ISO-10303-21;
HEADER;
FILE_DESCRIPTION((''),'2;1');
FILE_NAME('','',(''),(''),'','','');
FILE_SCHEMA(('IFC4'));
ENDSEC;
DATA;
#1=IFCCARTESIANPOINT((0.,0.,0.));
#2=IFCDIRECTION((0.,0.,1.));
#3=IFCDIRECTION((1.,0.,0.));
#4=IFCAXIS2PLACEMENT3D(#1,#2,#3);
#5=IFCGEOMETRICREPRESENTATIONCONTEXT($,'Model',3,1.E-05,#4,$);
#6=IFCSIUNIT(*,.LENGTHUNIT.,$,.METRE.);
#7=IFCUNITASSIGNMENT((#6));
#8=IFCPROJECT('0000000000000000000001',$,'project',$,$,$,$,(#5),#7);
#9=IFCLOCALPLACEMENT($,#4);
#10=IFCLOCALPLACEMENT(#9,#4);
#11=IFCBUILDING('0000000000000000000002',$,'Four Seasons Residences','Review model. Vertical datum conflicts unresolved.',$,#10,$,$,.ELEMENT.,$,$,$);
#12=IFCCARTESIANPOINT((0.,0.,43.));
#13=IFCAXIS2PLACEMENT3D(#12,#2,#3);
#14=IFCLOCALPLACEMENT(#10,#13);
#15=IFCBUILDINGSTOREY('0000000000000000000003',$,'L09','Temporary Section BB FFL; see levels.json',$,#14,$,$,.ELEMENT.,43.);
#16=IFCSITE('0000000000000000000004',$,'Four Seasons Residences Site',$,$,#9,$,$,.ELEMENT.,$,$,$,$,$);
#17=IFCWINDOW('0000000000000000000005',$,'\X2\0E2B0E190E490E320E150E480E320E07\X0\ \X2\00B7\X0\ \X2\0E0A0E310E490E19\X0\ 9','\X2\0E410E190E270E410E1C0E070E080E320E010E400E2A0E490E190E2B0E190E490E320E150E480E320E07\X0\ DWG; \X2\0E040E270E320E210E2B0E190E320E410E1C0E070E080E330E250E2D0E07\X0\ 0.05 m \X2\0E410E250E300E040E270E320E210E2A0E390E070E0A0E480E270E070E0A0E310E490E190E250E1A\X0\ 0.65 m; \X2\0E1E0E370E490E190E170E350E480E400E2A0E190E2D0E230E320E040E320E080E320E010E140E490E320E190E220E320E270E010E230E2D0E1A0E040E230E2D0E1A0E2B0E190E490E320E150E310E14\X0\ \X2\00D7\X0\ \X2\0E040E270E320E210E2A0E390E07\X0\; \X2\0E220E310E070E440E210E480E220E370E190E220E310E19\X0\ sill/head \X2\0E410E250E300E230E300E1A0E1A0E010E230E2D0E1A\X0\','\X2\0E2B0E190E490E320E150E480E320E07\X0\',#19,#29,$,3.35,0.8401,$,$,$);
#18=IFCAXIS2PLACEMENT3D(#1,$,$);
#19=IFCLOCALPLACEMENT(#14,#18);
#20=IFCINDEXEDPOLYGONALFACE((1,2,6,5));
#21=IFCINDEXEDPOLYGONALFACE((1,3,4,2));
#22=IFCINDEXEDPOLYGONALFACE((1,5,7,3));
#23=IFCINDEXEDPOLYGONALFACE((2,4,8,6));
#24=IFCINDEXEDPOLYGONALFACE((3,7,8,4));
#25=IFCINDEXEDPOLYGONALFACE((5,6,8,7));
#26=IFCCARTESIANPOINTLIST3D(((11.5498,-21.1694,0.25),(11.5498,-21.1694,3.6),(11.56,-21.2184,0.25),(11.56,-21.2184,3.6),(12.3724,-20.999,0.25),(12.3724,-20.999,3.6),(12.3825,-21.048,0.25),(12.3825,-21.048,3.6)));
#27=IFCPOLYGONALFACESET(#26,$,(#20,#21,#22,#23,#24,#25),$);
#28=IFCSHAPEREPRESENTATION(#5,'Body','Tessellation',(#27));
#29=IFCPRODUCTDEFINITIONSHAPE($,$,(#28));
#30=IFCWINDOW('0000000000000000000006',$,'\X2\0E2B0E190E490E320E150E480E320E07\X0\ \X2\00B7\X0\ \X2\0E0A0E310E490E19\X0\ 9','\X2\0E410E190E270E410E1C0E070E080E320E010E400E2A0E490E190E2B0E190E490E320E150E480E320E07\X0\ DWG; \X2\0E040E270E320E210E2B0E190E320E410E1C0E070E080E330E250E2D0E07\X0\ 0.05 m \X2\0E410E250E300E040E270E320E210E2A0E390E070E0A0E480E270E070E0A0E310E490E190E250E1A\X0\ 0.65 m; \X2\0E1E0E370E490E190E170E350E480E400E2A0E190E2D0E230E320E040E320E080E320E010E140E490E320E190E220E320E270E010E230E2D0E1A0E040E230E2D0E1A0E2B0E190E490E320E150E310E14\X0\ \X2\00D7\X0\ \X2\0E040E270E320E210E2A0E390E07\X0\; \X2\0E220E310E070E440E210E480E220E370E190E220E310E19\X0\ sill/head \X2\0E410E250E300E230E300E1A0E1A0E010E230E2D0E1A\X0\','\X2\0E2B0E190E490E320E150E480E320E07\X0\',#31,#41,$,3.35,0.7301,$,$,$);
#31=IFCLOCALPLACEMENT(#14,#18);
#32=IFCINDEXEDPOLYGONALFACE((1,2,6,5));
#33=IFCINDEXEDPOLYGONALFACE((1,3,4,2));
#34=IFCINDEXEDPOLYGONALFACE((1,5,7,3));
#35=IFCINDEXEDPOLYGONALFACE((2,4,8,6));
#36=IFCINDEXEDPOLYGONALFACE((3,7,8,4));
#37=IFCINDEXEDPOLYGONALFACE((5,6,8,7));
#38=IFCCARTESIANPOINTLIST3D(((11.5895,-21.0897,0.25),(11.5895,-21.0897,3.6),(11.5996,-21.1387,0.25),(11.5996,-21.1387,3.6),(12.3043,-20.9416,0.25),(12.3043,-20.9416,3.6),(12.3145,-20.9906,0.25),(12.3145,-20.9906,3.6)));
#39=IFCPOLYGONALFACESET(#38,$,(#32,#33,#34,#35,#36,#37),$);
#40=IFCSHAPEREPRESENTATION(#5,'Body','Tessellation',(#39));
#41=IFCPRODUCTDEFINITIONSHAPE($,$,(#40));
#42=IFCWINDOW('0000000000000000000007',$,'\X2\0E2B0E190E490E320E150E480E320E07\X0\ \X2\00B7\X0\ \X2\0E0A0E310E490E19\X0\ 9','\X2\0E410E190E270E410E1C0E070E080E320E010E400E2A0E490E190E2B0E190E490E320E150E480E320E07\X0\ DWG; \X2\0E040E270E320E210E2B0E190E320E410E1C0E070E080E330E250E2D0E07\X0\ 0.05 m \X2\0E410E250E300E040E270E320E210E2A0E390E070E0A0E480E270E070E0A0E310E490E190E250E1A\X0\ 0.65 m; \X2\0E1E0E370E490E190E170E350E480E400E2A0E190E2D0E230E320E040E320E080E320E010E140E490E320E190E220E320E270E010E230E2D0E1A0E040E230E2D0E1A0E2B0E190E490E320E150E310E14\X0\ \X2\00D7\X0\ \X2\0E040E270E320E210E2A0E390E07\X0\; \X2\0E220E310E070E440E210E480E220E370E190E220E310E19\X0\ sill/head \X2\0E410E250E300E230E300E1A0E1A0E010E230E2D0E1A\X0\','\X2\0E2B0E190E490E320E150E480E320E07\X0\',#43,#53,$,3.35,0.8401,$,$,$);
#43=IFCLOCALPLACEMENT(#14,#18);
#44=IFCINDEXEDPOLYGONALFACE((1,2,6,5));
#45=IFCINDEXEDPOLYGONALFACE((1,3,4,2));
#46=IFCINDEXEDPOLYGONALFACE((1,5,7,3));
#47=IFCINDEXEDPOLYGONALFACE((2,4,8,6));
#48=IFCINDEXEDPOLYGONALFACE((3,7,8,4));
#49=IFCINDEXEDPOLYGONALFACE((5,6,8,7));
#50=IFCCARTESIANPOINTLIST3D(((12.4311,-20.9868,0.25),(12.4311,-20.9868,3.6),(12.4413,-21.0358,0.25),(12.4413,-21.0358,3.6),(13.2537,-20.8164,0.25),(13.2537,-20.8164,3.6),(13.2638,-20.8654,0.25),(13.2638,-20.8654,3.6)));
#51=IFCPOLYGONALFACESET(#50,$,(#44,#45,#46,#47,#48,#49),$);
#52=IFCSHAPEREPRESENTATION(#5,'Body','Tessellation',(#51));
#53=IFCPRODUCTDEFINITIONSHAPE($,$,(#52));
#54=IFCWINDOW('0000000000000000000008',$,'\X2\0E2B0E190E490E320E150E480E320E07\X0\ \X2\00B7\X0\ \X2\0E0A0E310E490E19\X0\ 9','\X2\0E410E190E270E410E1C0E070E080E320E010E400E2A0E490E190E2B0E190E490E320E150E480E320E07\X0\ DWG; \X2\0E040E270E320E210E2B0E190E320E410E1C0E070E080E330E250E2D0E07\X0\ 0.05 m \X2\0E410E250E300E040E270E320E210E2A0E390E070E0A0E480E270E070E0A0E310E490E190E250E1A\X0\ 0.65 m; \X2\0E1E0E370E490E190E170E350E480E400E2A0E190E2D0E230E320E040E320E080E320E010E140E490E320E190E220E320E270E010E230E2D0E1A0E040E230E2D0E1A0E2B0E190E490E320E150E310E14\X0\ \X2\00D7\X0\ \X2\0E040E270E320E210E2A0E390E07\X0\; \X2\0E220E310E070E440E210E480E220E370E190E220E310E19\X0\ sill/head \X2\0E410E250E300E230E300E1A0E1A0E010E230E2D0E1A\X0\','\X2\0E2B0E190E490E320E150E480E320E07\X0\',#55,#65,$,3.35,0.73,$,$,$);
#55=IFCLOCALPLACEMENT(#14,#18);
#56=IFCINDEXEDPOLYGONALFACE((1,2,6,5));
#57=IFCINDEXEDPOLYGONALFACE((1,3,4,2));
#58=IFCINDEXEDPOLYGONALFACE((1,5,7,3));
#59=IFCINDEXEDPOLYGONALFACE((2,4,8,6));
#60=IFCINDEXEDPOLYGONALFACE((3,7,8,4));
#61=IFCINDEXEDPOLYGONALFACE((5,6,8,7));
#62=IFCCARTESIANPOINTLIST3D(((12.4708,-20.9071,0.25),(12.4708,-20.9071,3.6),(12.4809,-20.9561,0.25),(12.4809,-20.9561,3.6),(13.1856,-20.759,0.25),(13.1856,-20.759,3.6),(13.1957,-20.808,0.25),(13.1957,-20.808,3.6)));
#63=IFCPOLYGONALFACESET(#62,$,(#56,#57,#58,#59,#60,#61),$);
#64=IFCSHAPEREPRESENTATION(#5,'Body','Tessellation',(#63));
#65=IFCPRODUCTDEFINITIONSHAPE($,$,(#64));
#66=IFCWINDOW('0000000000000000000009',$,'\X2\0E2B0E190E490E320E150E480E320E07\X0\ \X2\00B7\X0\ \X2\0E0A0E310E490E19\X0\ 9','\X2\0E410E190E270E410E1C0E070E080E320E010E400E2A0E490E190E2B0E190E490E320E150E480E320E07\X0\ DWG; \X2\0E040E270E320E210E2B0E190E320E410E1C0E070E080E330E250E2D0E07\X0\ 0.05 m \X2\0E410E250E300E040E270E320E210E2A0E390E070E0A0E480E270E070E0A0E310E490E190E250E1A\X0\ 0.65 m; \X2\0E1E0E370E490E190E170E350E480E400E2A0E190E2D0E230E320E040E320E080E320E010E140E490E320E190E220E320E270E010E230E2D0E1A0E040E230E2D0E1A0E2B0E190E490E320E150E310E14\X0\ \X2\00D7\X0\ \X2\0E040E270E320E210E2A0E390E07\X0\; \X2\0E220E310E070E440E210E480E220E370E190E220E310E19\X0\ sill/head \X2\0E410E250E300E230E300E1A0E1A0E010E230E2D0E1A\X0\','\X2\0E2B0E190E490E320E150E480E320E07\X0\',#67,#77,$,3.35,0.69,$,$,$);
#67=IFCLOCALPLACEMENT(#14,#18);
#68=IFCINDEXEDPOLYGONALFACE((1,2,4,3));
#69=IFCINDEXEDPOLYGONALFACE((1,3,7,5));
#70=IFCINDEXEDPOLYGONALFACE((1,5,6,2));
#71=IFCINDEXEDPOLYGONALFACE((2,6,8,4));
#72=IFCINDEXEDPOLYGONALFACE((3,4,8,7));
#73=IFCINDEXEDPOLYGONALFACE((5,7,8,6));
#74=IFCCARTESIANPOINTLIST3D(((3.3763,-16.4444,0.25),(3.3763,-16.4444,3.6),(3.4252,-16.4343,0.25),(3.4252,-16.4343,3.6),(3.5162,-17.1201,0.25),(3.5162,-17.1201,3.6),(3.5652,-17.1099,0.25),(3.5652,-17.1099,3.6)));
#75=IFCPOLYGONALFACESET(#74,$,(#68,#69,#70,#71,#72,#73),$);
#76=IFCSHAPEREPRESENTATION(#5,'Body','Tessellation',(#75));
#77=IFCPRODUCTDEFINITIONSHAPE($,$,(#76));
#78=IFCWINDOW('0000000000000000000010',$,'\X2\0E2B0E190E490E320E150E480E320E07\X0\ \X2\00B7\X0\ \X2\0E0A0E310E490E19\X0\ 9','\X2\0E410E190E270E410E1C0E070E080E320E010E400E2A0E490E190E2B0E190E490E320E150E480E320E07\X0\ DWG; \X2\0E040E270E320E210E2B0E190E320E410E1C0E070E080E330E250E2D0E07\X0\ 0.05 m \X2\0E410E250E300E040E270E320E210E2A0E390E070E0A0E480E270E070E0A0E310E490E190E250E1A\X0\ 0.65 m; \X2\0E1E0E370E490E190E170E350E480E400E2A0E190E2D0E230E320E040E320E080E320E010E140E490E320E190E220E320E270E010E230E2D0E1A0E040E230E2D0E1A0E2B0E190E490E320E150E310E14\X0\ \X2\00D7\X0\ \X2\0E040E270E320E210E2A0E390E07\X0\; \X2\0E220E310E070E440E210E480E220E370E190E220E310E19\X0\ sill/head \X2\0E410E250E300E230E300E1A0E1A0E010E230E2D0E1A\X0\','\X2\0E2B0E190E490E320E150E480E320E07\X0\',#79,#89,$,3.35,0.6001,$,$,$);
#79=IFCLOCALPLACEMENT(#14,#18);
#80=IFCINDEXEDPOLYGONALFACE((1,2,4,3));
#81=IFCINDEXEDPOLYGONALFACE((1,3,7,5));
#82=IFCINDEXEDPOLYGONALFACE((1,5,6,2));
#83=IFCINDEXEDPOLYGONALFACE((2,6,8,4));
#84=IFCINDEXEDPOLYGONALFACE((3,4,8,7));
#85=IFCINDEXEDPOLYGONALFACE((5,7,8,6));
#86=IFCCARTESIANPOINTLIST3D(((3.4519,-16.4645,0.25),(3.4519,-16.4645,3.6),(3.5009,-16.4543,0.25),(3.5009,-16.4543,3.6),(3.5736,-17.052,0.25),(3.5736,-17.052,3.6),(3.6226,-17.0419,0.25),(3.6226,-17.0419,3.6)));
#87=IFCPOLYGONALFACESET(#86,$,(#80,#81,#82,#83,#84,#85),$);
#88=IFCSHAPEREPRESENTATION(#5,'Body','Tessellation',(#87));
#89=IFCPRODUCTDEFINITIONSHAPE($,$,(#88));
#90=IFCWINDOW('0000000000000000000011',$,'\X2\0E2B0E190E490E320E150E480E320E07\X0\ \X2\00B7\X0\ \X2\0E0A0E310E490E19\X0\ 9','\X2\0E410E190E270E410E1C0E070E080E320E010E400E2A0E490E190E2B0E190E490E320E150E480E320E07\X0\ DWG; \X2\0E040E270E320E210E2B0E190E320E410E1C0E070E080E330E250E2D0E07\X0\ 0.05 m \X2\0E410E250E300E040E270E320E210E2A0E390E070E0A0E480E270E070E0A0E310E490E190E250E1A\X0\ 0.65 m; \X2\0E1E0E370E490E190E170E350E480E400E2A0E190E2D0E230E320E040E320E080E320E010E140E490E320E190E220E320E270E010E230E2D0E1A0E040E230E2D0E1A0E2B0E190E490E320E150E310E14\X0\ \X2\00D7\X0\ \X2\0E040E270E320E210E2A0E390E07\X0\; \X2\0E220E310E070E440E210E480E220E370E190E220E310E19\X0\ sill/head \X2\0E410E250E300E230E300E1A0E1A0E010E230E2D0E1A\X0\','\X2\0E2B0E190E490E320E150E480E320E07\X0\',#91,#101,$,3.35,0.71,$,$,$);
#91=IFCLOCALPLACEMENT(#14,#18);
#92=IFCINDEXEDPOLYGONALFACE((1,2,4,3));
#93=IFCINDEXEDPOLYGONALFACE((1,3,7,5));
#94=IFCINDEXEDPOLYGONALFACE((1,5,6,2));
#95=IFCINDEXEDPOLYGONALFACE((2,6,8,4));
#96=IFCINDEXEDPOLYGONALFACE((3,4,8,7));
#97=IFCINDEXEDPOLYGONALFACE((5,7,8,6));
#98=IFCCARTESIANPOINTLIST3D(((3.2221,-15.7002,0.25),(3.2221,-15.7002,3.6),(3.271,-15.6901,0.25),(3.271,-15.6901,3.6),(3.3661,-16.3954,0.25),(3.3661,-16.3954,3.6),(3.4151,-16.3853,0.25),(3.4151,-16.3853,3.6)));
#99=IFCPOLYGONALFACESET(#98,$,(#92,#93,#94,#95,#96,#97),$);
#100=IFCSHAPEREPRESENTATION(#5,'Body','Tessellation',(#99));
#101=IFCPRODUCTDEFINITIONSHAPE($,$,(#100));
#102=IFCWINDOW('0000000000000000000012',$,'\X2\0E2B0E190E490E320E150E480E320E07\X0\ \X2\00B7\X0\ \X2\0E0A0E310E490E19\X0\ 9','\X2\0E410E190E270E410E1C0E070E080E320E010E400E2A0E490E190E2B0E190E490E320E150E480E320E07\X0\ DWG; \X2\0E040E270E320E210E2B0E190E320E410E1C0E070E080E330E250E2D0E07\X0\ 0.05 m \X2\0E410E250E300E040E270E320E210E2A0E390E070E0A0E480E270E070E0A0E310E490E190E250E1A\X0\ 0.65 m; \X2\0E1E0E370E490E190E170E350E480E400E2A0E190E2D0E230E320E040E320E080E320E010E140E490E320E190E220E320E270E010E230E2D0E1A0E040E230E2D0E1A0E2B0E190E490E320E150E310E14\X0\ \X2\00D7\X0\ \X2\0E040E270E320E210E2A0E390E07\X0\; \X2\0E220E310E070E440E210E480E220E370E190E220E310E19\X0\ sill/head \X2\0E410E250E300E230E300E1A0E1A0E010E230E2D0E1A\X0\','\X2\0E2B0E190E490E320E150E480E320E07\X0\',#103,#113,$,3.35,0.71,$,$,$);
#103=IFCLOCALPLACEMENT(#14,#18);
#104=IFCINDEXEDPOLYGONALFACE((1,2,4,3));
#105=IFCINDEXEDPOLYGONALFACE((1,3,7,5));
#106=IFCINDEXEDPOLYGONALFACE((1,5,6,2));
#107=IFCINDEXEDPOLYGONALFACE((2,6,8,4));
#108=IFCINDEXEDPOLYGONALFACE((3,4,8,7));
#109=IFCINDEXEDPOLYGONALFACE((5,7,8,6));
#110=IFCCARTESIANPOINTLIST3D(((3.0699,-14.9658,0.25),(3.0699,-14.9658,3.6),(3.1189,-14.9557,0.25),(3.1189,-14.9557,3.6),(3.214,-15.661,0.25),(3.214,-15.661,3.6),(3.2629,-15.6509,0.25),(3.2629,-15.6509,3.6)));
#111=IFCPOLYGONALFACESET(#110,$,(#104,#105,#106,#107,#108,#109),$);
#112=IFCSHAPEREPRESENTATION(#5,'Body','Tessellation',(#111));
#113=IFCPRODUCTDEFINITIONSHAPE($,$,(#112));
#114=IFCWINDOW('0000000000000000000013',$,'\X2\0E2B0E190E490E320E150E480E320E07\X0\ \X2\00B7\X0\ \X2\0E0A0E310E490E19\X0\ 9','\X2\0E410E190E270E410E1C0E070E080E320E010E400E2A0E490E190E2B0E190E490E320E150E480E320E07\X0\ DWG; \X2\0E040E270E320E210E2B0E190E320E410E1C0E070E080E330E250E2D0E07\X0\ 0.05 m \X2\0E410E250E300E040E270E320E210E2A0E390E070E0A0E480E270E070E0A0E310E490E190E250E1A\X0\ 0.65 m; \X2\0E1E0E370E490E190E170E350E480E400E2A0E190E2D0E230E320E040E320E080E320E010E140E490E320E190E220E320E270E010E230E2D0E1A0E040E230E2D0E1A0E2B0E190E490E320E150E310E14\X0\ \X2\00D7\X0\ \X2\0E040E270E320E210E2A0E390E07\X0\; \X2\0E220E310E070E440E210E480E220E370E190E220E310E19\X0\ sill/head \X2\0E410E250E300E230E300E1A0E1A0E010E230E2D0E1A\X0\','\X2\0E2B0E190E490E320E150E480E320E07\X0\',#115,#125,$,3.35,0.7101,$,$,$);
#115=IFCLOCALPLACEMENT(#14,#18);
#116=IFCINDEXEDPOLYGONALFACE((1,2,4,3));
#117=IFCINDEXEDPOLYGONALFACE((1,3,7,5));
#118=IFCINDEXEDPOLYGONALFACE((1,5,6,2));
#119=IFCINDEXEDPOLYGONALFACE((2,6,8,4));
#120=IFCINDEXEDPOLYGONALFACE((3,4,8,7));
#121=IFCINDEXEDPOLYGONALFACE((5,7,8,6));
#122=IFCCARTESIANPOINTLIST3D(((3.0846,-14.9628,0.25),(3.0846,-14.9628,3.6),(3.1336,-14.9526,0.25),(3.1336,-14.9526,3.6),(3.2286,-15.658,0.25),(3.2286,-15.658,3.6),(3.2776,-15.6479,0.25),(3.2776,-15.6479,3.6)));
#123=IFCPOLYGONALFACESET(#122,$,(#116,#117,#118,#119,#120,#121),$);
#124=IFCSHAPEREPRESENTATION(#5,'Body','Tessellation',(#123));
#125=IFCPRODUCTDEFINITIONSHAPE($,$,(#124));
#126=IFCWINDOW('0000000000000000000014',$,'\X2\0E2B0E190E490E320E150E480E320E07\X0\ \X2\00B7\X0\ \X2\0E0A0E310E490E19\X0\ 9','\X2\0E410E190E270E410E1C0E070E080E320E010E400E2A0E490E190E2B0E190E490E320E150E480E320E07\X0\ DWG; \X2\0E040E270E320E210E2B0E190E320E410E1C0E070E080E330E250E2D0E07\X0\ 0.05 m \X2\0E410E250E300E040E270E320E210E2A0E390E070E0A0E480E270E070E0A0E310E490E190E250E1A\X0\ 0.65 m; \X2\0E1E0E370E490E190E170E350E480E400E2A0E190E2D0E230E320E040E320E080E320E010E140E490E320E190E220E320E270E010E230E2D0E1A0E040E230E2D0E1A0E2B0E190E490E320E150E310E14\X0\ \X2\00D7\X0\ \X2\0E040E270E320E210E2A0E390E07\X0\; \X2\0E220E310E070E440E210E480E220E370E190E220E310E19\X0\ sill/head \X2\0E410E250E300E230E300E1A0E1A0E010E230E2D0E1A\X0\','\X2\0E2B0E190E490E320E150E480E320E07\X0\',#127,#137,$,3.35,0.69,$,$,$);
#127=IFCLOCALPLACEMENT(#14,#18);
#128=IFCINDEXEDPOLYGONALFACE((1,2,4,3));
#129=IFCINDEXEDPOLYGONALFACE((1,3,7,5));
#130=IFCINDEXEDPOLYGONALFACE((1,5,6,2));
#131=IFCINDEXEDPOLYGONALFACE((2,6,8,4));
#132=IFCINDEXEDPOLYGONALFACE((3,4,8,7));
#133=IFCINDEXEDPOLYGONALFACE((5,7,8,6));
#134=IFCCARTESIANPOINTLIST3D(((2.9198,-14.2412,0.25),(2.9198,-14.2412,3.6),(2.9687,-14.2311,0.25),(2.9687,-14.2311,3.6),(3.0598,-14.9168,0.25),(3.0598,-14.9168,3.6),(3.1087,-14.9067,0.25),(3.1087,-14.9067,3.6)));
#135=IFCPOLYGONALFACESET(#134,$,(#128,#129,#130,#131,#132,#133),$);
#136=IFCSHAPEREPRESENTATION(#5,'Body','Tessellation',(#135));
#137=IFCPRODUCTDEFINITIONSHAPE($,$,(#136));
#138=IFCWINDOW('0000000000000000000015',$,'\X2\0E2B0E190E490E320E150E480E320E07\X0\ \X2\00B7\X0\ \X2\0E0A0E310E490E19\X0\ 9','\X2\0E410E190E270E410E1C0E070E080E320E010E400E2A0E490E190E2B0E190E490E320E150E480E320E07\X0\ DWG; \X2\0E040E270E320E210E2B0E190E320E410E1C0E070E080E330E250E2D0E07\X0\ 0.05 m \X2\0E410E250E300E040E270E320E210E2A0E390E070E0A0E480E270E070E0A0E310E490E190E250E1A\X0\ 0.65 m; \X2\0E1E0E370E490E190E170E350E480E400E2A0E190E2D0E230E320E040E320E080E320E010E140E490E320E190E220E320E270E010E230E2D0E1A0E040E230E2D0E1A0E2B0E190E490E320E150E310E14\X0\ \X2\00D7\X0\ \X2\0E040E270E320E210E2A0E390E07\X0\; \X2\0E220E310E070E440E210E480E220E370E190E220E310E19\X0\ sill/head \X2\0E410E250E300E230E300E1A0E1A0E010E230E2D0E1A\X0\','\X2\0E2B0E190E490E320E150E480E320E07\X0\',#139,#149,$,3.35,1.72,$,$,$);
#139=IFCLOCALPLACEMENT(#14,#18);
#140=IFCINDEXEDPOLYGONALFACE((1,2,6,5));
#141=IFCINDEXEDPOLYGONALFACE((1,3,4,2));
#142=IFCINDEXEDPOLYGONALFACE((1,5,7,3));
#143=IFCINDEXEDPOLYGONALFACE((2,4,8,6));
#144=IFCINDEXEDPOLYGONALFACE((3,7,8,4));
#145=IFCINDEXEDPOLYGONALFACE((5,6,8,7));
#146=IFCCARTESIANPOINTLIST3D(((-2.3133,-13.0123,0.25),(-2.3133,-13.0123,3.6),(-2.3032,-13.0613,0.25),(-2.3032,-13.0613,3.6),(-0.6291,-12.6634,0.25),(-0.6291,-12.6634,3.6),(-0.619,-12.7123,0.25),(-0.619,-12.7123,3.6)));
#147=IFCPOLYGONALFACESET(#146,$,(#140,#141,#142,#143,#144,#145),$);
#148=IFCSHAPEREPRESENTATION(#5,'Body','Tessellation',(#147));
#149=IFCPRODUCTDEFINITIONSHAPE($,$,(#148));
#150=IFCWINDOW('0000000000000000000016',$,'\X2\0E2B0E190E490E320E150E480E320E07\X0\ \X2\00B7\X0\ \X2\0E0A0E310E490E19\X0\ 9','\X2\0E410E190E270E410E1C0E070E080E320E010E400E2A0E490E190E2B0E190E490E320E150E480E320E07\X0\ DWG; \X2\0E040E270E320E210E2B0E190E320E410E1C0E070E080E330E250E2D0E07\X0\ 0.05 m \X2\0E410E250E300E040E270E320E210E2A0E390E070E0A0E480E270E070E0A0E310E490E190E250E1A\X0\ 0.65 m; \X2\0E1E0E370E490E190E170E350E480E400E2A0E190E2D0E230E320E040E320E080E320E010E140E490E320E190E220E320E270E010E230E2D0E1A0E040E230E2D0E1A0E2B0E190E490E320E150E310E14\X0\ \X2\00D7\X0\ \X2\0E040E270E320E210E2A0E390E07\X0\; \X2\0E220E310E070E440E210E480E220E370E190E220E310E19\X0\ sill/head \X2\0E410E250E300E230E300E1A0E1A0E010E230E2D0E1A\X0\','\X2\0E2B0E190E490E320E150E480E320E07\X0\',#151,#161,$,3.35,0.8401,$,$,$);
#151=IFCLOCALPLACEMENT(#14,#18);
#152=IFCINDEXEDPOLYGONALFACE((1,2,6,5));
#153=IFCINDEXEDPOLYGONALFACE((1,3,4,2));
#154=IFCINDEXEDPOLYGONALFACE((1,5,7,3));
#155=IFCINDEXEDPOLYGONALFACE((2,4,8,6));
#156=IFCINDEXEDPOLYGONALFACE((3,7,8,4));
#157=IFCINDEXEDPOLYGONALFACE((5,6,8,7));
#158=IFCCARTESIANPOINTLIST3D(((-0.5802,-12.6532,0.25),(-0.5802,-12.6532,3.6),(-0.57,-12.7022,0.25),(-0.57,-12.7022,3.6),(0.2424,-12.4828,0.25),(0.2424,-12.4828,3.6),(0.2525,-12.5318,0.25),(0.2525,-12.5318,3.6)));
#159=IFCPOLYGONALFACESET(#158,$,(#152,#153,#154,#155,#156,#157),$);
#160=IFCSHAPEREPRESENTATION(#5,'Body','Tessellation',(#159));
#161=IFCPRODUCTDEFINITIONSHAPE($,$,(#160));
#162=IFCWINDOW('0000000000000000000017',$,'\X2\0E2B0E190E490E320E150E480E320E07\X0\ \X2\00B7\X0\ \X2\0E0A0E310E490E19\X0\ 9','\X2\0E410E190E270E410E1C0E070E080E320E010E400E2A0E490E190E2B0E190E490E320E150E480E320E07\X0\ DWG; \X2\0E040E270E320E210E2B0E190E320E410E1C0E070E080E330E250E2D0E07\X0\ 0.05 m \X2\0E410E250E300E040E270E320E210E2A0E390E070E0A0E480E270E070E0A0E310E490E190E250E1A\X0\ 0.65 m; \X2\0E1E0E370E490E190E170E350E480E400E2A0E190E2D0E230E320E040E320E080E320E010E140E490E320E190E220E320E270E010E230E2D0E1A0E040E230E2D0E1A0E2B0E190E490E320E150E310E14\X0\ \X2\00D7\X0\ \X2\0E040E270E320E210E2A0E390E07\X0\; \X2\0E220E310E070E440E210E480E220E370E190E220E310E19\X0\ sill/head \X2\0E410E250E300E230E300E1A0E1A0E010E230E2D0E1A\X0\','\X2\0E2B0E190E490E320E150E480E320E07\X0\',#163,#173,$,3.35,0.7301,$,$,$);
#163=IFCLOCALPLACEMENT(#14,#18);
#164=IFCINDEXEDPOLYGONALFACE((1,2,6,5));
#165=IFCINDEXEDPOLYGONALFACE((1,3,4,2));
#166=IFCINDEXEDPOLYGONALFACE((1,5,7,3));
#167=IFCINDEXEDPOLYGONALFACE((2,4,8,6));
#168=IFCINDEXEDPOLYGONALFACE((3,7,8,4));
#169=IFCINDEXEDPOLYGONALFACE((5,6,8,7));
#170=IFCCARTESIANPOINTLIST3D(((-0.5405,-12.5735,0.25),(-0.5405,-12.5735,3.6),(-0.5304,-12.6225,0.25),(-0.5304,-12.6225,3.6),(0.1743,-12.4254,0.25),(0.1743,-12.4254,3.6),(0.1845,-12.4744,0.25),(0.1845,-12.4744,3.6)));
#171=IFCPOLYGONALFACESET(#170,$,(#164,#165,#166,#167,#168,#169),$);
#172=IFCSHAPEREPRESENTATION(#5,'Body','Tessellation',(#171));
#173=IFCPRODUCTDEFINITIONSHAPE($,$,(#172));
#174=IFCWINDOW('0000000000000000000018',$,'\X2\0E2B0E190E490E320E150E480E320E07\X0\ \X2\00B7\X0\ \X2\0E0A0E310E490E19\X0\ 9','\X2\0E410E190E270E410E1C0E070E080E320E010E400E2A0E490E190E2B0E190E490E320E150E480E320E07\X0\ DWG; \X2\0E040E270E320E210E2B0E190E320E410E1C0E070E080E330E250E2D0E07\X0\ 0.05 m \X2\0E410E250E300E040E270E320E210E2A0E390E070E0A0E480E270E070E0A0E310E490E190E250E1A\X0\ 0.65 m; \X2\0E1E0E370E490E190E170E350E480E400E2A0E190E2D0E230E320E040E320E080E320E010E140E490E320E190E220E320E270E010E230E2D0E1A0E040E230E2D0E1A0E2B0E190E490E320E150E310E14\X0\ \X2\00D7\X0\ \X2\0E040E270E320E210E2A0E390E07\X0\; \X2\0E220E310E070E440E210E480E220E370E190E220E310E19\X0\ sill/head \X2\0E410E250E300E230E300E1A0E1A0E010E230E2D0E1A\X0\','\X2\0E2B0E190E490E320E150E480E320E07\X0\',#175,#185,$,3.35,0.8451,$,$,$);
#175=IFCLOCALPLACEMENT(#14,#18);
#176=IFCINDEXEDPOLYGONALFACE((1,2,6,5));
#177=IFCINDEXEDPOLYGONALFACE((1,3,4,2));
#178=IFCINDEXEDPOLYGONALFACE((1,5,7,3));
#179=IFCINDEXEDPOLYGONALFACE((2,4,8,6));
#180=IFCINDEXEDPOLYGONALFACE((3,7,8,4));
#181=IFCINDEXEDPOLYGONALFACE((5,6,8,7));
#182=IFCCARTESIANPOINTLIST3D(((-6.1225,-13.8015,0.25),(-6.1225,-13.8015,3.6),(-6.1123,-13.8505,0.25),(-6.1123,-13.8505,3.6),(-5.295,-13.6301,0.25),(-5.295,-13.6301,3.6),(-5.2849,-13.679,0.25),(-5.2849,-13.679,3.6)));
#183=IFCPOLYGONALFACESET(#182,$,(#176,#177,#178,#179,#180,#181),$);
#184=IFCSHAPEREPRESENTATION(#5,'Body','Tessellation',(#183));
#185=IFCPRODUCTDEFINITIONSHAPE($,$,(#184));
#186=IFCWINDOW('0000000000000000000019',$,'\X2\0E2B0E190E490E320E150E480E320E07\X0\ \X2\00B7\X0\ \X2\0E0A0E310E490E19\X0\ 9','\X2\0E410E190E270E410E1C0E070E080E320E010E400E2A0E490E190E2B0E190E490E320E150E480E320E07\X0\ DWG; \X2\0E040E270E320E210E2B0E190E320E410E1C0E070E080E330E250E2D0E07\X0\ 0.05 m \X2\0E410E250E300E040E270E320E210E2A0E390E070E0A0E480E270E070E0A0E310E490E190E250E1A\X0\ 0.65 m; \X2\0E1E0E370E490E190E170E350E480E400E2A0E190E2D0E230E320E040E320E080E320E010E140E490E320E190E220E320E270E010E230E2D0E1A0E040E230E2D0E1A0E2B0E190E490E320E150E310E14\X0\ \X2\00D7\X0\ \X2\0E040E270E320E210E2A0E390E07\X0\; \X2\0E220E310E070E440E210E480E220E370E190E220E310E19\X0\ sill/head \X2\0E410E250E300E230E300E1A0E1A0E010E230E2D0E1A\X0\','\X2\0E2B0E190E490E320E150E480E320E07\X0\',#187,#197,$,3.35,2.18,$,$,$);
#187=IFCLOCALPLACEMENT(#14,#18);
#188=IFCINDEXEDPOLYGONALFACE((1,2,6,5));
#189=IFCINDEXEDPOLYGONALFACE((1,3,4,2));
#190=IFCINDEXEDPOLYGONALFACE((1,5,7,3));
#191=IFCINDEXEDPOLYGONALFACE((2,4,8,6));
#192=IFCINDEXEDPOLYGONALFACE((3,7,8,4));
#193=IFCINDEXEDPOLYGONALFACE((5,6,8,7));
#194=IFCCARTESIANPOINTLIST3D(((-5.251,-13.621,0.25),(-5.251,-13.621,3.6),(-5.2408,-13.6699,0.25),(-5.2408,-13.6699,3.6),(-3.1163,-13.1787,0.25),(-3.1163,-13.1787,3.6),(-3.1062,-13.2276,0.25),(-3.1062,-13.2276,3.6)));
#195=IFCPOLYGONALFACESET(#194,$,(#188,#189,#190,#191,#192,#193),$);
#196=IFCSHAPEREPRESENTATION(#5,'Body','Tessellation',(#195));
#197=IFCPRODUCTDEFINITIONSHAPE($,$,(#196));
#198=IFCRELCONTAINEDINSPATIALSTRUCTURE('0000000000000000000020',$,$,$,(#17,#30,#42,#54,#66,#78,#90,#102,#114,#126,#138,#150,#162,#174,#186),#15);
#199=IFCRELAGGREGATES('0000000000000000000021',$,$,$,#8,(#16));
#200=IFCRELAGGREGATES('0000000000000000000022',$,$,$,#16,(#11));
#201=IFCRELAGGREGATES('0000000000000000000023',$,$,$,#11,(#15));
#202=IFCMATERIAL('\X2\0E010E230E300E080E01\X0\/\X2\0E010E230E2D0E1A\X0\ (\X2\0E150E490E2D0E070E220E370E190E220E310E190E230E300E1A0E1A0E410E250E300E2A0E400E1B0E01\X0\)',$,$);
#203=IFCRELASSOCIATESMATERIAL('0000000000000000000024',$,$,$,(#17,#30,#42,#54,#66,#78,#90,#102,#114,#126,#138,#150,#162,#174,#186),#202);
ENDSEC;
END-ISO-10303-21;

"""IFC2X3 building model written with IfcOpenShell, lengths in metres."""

from ifc_helpers import new_model, si_unit, frame, origin_with_axes, place, context, project, spatial, polyline, outline, extrude, material, element, save


model = new_model("IFC2X3")

# Units and contexts
model_context = context("Model", 3, precision=1e-05, world=origin_with_axes())
ifc_project = project(units=[si_unit("LENGTHUNIT", "METRE")], contexts=[model_context])

# Site, building, storey
site_placement = place(None, origin_with_axes())
site = spatial("IfcSite", under=ifc_project, at=site_placement, Name="Four Seasons Residences Site", CompositionType="ELEMENT")
building_placement = place(site_placement, origin_with_axes())
building = spatial("IfcBuilding", under=site, at=building_placement, Name="Four Seasons Residences", Description="Review model. Vertical datum conflicts unresolved.", CompositionType="ELEMENT")
storey_placement = place(building_placement, frame((0.0, 0.0, 43.0), z_axis=(0.0, 0.0, 1.0), x_axis=(1.0, 0.0, 0.0)))
storey = spatial("IfcBuildingStorey", under=building, at=storey_placement, Name="L09", Description="Temporary Section BB FFL; see levels.json", CompositionType="ELEMENT", Elevation=43.0)

# Windows
ifc_material = material(Name="กระจก/กรอบ (ต้องยืนยันระบบและสเปก)")
window_1_placement = place(storey_placement, origin_with_axes())
element("IfcWindow", 1, at=window_1_placement, inside=storey, material=ifc_material, Name="หน้าต่าง · ชั้น 9", Description="แนวแผงจากเส้นหน้าต่าง DWG; ความหนาแผงจำลอง 0.05 m และความสูงช่วงชั้นลบ 0.65 m; พื้นที่เสนอราคาจากด้านยาวกรอบครอบหน้าตัด × ความสูง; ยังไม่ยืนยัน sill/head และระบบกรอบ", ObjectType="หน้าต่าง", OverallHeight=3.35, OverallWidth=0.8401, context=model_context, shape_type="SweptSolid", body=[
    extrude(outline(polyline([(12.3724, -20.999), (12.3825, -21.048), (11.56, -21.2184), (11.5498, -21.1694), (12.3724, -20.999)])), frame((0.0, 0.0, 0.25), z_axis=(0.0, 0.0, 1.0), x_axis=(1.0, 0.0, 0.0)), (0.0, 0.0, 1.0), 3.35),
])
window_2_placement = place(storey_placement, origin_with_axes())
element("IfcWindow", 2, at=window_2_placement, inside=storey, material=ifc_material, Name="หน้าต่าง · ชั้น 9", Description="แนวแผงจากเส้นหน้าต่าง DWG; ความหนาแผงจำลอง 0.05 m และความสูงช่วงชั้นลบ 0.65 m; พื้นที่เสนอราคาจากด้านยาวกรอบครอบหน้าตัด × ความสูง; ยังไม่ยืนยัน sill/head และระบบกรอบ", ObjectType="หน้าต่าง", OverallHeight=3.35, OverallWidth=0.7301, context=model_context, shape_type="SweptSolid", body=[
    extrude(outline(polyline([(12.3043, -20.9416), (12.3145, -20.9906), (11.5996, -21.1387), (11.5895, -21.0897), (12.3043, -20.9416)])), frame((0.0, 0.0, 0.25), z_axis=(0.0, 0.0, 1.0), x_axis=(1.0, 0.0, 0.0)), (0.0, 0.0, 1.0), 3.35),
])
window_3_placement = place(storey_placement, origin_with_axes())
element("IfcWindow", 3, at=window_3_placement, inside=storey, material=ifc_material, Name="หน้าต่าง · ชั้น 9", Description="แนวแผงจากเส้นหน้าต่าง DWG; ความหนาแผงจำลอง 0.05 m และความสูงช่วงชั้นลบ 0.65 m; พื้นที่เสนอราคาจากด้านยาวกรอบครอบหน้าตัด × ความสูง; ยังไม่ยืนยัน sill/head และระบบกรอบ", ObjectType="หน้าต่าง", OverallHeight=3.35, OverallWidth=0.8401, context=model_context, shape_type="SweptSolid", body=[
    extrude(outline(polyline([(13.2537, -20.8164), (13.2638, -20.8654), (12.4413, -21.0358), (12.4311, -20.9868), (13.2537, -20.8164)])), frame((0.0, 0.0, 0.25), z_axis=(0.0, 0.0, 1.0), x_axis=(1.0, 0.0, 0.0)), (0.0, 0.0, 1.0), 3.35),
])
window_4_placement = place(storey_placement, origin_with_axes())
element("IfcWindow", 4, at=window_4_placement, inside=storey, material=ifc_material, Name="หน้าต่าง · ชั้น 9", Description="แนวแผงจากเส้นหน้าต่าง DWG; ความหนาแผงจำลอง 0.05 m และความสูงช่วงชั้นลบ 0.65 m; พื้นที่เสนอราคาจากด้านยาวกรอบครอบหน้าตัด × ความสูง; ยังไม่ยืนยัน sill/head และระบบกรอบ", ObjectType="หน้าต่าง", OverallHeight=3.35, OverallWidth=0.73, context=model_context, shape_type="SweptSolid", body=[
    extrude(outline(polyline([(13.1856, -20.759), (13.1957, -20.808), (12.4809, -20.9561), (12.4708, -20.9071), (13.1856, -20.759)])), frame((0.0, 0.0, 0.25), z_axis=(0.0, 0.0, 1.0), x_axis=(1.0, 0.0, 0.0)), (0.0, 0.0, 1.0), 3.35),
])
window_5_placement = place(storey_placement, origin_with_axes())
element("IfcWindow", 5, at=window_5_placement, inside=storey, material=ifc_material, Name="หน้าต่าง · ชั้น 9", Description="แนวแผงจากเส้นหน้าต่าง DWG; ความหนาแผงจำลอง 0.05 m และความสูงช่วงชั้นลบ 0.65 m; พื้นที่เสนอราคาจากด้านยาวกรอบครอบหน้าตัด × ความสูง; ยังไม่ยืนยัน sill/head และระบบกรอบ", ObjectType="หน้าต่าง", OverallHeight=3.35, OverallWidth=0.69, context=model_context, shape_type="SweptSolid", body=[
    extrude(outline(polyline([(3.3763, -16.4444), (3.4252, -16.4343), (3.5652, -17.1099), (3.5162, -17.1201), (3.3763, -16.4444)])), frame((0.0, 0.0, 0.25), z_axis=(0.0, 0.0, 1.0), x_axis=(1.0, 0.0, 0.0)), (0.0, 0.0, 1.0), 3.35),
])
window_6_placement = place(storey_placement, origin_with_axes())
element("IfcWindow", 6, at=window_6_placement, inside=storey, material=ifc_material, Name="หน้าต่าง · ชั้น 9", Description="แนวแผงจากเส้นหน้าต่าง DWG; ความหนาแผงจำลอง 0.05 m และความสูงช่วงชั้นลบ 0.65 m; พื้นที่เสนอราคาจากด้านยาวกรอบครอบหน้าตัด × ความสูง; ยังไม่ยืนยัน sill/head และระบบกรอบ", ObjectType="หน้าต่าง", OverallHeight=3.35, OverallWidth=0.6001, context=model_context, shape_type="SweptSolid", body=[
    extrude(outline(polyline([(3.4519, -16.4645), (3.5009, -16.4543), (3.6226, -17.0419), (3.5736, -17.052), (3.4519, -16.4645)])), frame((0.0, 0.0, 0.25), z_axis=(0.0, 0.0, 1.0), x_axis=(1.0, 0.0, 0.0)), (0.0, 0.0, 1.0), 3.35),
])
window_7_placement = place(storey_placement, origin_with_axes())
element("IfcWindow", 7, at=window_7_placement, inside=storey, material=ifc_material, Name="หน้าต่าง · ชั้น 9", Description="แนวแผงจากเส้นหน้าต่าง DWG; ความหนาแผงจำลอง 0.05 m และความสูงช่วงชั้นลบ 0.65 m; พื้นที่เสนอราคาจากด้านยาวกรอบครอบหน้าตัด × ความสูง; ยังไม่ยืนยัน sill/head และระบบกรอบ", ObjectType="หน้าต่าง", OverallHeight=3.35, OverallWidth=0.71, context=model_context, shape_type="SweptSolid", body=[
    extrude(outline(polyline([(3.2221, -15.7002), (3.271, -15.6901), (3.4151, -16.3853), (3.3661, -16.3954), (3.2221, -15.7002)])), frame((0.0, 0.0, 0.25), z_axis=(0.0, 0.0, 1.0), x_axis=(1.0, 0.0, 0.0)), (0.0, 0.0, 1.0), 3.35),
])
window_8_placement = place(storey_placement, origin_with_axes())
element("IfcWindow", 8, at=window_8_placement, inside=storey, material=ifc_material, Name="หน้าต่าง · ชั้น 9", Description="แนวแผงจากเส้นหน้าต่าง DWG; ความหนาแผงจำลอง 0.05 m และความสูงช่วงชั้นลบ 0.65 m; พื้นที่เสนอราคาจากด้านยาวกรอบครอบหน้าตัด × ความสูง; ยังไม่ยืนยัน sill/head และระบบกรอบ", ObjectType="หน้าต่าง", OverallHeight=3.35, OverallWidth=0.71, context=model_context, shape_type="SweptSolid", body=[
    extrude(outline(polyline([(3.0699, -14.9658), (3.1189, -14.9557), (3.2629, -15.6509), (3.214, -15.661), (3.0699, -14.9658)])), frame((0.0, 0.0, 0.25), z_axis=(0.0, 0.0, 1.0), x_axis=(1.0, 0.0, 0.0)), (0.0, 0.0, 1.0), 3.35),
])
window_9_placement = place(storey_placement, origin_with_axes())
element("IfcWindow", 9, at=window_9_placement, inside=storey, material=ifc_material, Name="หน้าต่าง · ชั้น 9", Description="แนวแผงจากเส้นหน้าต่าง DWG; ความหนาแผงจำลอง 0.05 m และความสูงช่วงชั้นลบ 0.65 m; พื้นที่เสนอราคาจากด้านยาวกรอบครอบหน้าตัด × ความสูง; ยังไม่ยืนยัน sill/head และระบบกรอบ", ObjectType="หน้าต่าง", OverallHeight=3.35, OverallWidth=0.7101, context=model_context, shape_type="SweptSolid", body=[
    extrude(outline(polyline([(3.0846, -14.9628), (3.1336, -14.9526), (3.2776, -15.6479), (3.2286, -15.658), (3.0846, -14.9628)])), frame((0.0, 0.0, 0.25), z_axis=(0.0, 0.0, 1.0), x_axis=(1.0, 0.0, 0.0)), (0.0, 0.0, 1.0), 3.35),
])
window_10_placement = place(storey_placement, origin_with_axes())
element("IfcWindow", 10, at=window_10_placement, inside=storey, material=ifc_material, Name="หน้าต่าง · ชั้น 9", Description="แนวแผงจากเส้นหน้าต่าง DWG; ความหนาแผงจำลอง 0.05 m และความสูงช่วงชั้นลบ 0.65 m; พื้นที่เสนอราคาจากด้านยาวกรอบครอบหน้าตัด × ความสูง; ยังไม่ยืนยัน sill/head และระบบกรอบ", ObjectType="หน้าต่าง", OverallHeight=3.35, OverallWidth=0.69, context=model_context, shape_type="SweptSolid", body=[
    extrude(outline(polyline([(2.9198, -14.2412), (2.9687, -14.2311), (3.1087, -14.9067), (3.0598, -14.9168), (2.9198, -14.2412)])), frame((0.0, 0.0, 0.25), z_axis=(0.0, 0.0, 1.0), x_axis=(1.0, 0.0, 0.0)), (0.0, 0.0, 1.0), 3.35),
])
window_11_placement = place(storey_placement, origin_with_axes())
element("IfcWindow", 11, at=window_11_placement, inside=storey, material=ifc_material, Name="หน้าต่าง · ชั้น 9", Description="แนวแผงจากเส้นหน้าต่าง DWG; ความหนาแผงจำลอง 0.05 m และความสูงช่วงชั้นลบ 0.65 m; พื้นที่เสนอราคาจากด้านยาวกรอบครอบหน้าตัด × ความสูง; ยังไม่ยืนยัน sill/head และระบบกรอบ", ObjectType="หน้าต่าง", OverallHeight=3.35, OverallWidth=1.72, context=model_context, shape_type="SweptSolid", body=[
    extrude(outline(polyline([(-0.6291, -12.6634), (-0.619, -12.7123), (-2.3032, -13.0613), (-2.3133, -13.0123), (-0.6291, -12.6634)])), frame((0.0, 0.0, 0.25), z_axis=(0.0, 0.0, 1.0), x_axis=(1.0, 0.0, 0.0)), (0.0, 0.0, 1.0), 3.35),
])
window_12_placement = place(storey_placement, origin_with_axes())
element("IfcWindow", 12, at=window_12_placement, inside=storey, material=ifc_material, Name="หน้าต่าง · ชั้น 9", Description="แนวแผงจากเส้นหน้าต่าง DWG; ความหนาแผงจำลอง 0.05 m และความสูงช่วงชั้นลบ 0.65 m; พื้นที่เสนอราคาจากด้านยาวกรอบครอบหน้าตัด × ความสูง; ยังไม่ยืนยัน sill/head และระบบกรอบ", ObjectType="หน้าต่าง", OverallHeight=3.35, OverallWidth=0.8401, context=model_context, shape_type="SweptSolid", body=[
    extrude(outline(polyline([(0.2424, -12.4828), (0.2525, -12.5318), (-0.57, -12.7022), (-0.5802, -12.6532), (0.2424, -12.4828)])), frame((0.0, 0.0, 0.25), z_axis=(0.0, 0.0, 1.0), x_axis=(1.0, 0.0, 0.0)), (0.0, 0.0, 1.0), 3.35),
])
window_13_placement = place(storey_placement, origin_with_axes())
element("IfcWindow", 13, at=window_13_placement, inside=storey, material=ifc_material, Name="หน้าต่าง · ชั้น 9", Description="แนวแผงจากเส้นหน้าต่าง DWG; ความหนาแผงจำลอง 0.05 m และความสูงช่วงชั้นลบ 0.65 m; พื้นที่เสนอราคาจากด้านยาวกรอบครอบหน้าตัด × ความสูง; ยังไม่ยืนยัน sill/head และระบบกรอบ", ObjectType="หน้าต่าง", OverallHeight=3.35, OverallWidth=0.7301, context=model_context, shape_type="SweptSolid", body=[
    extrude(outline(polyline([(0.1743, -12.4254), (0.1845, -12.4744), (-0.5304, -12.6225), (-0.5405, -12.5735), (0.1743, -12.4254)])), frame((0.0, 0.0, 0.25), z_axis=(0.0, 0.0, 1.0), x_axis=(1.0, 0.0, 0.0)), (0.0, 0.0, 1.0), 3.35),
])
window_14_placement = place(storey_placement, origin_with_axes())
element("IfcWindow", 14, at=window_14_placement, inside=storey, material=ifc_material, Name="หน้าต่าง · ชั้น 9", Description="แนวแผงจากเส้นหน้าต่าง DWG; ความหนาแผงจำลอง 0.05 m และความสูงช่วงชั้นลบ 0.65 m; พื้นที่เสนอราคาจากด้านยาวกรอบครอบหน้าตัด × ความสูง; ยังไม่ยืนยัน sill/head และระบบกรอบ", ObjectType="หน้าต่าง", OverallHeight=3.35, OverallWidth=0.8451, context=model_context, shape_type="SweptSolid", body=[
    extrude(outline(polyline([(-5.295, -13.6301), (-5.2849, -13.679), (-6.1123, -13.8505), (-6.1225, -13.8015), (-5.295, -13.6301)])), frame((0.0, 0.0, 0.25), z_axis=(0.0, 0.0, 1.0), x_axis=(1.0, 0.0, 0.0)), (0.0, 0.0, 1.0), 3.35),
])
window_15_placement = place(storey_placement, origin_with_axes())
element("IfcWindow", 15, at=window_15_placement, inside=storey, material=ifc_material, Name="หน้าต่าง · ชั้น 9", Description="แนวแผงจากเส้นหน้าต่าง DWG; ความหนาแผงจำลอง 0.05 m และความสูงช่วงชั้นลบ 0.65 m; พื้นที่เสนอราคาจากด้านยาวกรอบครอบหน้าตัด × ความสูง; ยังไม่ยืนยัน sill/head และระบบกรอบ", ObjectType="หน้าต่าง", OverallHeight=3.35, OverallWidth=2.18, context=model_context, shape_type="SweptSolid", body=[
    extrude(outline(polyline([(-3.1163, -13.1787), (-3.1062, -13.2276), (-5.2408, -13.6699), (-5.251, -13.621), (-3.1163, -13.1787)])), frame((0.0, 0.0, 0.25), z_axis=(0.0, 0.0, 1.0), x_axis=(1.0, 0.0, 0.0)), (0.0, 0.0, 1.0), 3.35),
])

save(model, "model.ifc")
